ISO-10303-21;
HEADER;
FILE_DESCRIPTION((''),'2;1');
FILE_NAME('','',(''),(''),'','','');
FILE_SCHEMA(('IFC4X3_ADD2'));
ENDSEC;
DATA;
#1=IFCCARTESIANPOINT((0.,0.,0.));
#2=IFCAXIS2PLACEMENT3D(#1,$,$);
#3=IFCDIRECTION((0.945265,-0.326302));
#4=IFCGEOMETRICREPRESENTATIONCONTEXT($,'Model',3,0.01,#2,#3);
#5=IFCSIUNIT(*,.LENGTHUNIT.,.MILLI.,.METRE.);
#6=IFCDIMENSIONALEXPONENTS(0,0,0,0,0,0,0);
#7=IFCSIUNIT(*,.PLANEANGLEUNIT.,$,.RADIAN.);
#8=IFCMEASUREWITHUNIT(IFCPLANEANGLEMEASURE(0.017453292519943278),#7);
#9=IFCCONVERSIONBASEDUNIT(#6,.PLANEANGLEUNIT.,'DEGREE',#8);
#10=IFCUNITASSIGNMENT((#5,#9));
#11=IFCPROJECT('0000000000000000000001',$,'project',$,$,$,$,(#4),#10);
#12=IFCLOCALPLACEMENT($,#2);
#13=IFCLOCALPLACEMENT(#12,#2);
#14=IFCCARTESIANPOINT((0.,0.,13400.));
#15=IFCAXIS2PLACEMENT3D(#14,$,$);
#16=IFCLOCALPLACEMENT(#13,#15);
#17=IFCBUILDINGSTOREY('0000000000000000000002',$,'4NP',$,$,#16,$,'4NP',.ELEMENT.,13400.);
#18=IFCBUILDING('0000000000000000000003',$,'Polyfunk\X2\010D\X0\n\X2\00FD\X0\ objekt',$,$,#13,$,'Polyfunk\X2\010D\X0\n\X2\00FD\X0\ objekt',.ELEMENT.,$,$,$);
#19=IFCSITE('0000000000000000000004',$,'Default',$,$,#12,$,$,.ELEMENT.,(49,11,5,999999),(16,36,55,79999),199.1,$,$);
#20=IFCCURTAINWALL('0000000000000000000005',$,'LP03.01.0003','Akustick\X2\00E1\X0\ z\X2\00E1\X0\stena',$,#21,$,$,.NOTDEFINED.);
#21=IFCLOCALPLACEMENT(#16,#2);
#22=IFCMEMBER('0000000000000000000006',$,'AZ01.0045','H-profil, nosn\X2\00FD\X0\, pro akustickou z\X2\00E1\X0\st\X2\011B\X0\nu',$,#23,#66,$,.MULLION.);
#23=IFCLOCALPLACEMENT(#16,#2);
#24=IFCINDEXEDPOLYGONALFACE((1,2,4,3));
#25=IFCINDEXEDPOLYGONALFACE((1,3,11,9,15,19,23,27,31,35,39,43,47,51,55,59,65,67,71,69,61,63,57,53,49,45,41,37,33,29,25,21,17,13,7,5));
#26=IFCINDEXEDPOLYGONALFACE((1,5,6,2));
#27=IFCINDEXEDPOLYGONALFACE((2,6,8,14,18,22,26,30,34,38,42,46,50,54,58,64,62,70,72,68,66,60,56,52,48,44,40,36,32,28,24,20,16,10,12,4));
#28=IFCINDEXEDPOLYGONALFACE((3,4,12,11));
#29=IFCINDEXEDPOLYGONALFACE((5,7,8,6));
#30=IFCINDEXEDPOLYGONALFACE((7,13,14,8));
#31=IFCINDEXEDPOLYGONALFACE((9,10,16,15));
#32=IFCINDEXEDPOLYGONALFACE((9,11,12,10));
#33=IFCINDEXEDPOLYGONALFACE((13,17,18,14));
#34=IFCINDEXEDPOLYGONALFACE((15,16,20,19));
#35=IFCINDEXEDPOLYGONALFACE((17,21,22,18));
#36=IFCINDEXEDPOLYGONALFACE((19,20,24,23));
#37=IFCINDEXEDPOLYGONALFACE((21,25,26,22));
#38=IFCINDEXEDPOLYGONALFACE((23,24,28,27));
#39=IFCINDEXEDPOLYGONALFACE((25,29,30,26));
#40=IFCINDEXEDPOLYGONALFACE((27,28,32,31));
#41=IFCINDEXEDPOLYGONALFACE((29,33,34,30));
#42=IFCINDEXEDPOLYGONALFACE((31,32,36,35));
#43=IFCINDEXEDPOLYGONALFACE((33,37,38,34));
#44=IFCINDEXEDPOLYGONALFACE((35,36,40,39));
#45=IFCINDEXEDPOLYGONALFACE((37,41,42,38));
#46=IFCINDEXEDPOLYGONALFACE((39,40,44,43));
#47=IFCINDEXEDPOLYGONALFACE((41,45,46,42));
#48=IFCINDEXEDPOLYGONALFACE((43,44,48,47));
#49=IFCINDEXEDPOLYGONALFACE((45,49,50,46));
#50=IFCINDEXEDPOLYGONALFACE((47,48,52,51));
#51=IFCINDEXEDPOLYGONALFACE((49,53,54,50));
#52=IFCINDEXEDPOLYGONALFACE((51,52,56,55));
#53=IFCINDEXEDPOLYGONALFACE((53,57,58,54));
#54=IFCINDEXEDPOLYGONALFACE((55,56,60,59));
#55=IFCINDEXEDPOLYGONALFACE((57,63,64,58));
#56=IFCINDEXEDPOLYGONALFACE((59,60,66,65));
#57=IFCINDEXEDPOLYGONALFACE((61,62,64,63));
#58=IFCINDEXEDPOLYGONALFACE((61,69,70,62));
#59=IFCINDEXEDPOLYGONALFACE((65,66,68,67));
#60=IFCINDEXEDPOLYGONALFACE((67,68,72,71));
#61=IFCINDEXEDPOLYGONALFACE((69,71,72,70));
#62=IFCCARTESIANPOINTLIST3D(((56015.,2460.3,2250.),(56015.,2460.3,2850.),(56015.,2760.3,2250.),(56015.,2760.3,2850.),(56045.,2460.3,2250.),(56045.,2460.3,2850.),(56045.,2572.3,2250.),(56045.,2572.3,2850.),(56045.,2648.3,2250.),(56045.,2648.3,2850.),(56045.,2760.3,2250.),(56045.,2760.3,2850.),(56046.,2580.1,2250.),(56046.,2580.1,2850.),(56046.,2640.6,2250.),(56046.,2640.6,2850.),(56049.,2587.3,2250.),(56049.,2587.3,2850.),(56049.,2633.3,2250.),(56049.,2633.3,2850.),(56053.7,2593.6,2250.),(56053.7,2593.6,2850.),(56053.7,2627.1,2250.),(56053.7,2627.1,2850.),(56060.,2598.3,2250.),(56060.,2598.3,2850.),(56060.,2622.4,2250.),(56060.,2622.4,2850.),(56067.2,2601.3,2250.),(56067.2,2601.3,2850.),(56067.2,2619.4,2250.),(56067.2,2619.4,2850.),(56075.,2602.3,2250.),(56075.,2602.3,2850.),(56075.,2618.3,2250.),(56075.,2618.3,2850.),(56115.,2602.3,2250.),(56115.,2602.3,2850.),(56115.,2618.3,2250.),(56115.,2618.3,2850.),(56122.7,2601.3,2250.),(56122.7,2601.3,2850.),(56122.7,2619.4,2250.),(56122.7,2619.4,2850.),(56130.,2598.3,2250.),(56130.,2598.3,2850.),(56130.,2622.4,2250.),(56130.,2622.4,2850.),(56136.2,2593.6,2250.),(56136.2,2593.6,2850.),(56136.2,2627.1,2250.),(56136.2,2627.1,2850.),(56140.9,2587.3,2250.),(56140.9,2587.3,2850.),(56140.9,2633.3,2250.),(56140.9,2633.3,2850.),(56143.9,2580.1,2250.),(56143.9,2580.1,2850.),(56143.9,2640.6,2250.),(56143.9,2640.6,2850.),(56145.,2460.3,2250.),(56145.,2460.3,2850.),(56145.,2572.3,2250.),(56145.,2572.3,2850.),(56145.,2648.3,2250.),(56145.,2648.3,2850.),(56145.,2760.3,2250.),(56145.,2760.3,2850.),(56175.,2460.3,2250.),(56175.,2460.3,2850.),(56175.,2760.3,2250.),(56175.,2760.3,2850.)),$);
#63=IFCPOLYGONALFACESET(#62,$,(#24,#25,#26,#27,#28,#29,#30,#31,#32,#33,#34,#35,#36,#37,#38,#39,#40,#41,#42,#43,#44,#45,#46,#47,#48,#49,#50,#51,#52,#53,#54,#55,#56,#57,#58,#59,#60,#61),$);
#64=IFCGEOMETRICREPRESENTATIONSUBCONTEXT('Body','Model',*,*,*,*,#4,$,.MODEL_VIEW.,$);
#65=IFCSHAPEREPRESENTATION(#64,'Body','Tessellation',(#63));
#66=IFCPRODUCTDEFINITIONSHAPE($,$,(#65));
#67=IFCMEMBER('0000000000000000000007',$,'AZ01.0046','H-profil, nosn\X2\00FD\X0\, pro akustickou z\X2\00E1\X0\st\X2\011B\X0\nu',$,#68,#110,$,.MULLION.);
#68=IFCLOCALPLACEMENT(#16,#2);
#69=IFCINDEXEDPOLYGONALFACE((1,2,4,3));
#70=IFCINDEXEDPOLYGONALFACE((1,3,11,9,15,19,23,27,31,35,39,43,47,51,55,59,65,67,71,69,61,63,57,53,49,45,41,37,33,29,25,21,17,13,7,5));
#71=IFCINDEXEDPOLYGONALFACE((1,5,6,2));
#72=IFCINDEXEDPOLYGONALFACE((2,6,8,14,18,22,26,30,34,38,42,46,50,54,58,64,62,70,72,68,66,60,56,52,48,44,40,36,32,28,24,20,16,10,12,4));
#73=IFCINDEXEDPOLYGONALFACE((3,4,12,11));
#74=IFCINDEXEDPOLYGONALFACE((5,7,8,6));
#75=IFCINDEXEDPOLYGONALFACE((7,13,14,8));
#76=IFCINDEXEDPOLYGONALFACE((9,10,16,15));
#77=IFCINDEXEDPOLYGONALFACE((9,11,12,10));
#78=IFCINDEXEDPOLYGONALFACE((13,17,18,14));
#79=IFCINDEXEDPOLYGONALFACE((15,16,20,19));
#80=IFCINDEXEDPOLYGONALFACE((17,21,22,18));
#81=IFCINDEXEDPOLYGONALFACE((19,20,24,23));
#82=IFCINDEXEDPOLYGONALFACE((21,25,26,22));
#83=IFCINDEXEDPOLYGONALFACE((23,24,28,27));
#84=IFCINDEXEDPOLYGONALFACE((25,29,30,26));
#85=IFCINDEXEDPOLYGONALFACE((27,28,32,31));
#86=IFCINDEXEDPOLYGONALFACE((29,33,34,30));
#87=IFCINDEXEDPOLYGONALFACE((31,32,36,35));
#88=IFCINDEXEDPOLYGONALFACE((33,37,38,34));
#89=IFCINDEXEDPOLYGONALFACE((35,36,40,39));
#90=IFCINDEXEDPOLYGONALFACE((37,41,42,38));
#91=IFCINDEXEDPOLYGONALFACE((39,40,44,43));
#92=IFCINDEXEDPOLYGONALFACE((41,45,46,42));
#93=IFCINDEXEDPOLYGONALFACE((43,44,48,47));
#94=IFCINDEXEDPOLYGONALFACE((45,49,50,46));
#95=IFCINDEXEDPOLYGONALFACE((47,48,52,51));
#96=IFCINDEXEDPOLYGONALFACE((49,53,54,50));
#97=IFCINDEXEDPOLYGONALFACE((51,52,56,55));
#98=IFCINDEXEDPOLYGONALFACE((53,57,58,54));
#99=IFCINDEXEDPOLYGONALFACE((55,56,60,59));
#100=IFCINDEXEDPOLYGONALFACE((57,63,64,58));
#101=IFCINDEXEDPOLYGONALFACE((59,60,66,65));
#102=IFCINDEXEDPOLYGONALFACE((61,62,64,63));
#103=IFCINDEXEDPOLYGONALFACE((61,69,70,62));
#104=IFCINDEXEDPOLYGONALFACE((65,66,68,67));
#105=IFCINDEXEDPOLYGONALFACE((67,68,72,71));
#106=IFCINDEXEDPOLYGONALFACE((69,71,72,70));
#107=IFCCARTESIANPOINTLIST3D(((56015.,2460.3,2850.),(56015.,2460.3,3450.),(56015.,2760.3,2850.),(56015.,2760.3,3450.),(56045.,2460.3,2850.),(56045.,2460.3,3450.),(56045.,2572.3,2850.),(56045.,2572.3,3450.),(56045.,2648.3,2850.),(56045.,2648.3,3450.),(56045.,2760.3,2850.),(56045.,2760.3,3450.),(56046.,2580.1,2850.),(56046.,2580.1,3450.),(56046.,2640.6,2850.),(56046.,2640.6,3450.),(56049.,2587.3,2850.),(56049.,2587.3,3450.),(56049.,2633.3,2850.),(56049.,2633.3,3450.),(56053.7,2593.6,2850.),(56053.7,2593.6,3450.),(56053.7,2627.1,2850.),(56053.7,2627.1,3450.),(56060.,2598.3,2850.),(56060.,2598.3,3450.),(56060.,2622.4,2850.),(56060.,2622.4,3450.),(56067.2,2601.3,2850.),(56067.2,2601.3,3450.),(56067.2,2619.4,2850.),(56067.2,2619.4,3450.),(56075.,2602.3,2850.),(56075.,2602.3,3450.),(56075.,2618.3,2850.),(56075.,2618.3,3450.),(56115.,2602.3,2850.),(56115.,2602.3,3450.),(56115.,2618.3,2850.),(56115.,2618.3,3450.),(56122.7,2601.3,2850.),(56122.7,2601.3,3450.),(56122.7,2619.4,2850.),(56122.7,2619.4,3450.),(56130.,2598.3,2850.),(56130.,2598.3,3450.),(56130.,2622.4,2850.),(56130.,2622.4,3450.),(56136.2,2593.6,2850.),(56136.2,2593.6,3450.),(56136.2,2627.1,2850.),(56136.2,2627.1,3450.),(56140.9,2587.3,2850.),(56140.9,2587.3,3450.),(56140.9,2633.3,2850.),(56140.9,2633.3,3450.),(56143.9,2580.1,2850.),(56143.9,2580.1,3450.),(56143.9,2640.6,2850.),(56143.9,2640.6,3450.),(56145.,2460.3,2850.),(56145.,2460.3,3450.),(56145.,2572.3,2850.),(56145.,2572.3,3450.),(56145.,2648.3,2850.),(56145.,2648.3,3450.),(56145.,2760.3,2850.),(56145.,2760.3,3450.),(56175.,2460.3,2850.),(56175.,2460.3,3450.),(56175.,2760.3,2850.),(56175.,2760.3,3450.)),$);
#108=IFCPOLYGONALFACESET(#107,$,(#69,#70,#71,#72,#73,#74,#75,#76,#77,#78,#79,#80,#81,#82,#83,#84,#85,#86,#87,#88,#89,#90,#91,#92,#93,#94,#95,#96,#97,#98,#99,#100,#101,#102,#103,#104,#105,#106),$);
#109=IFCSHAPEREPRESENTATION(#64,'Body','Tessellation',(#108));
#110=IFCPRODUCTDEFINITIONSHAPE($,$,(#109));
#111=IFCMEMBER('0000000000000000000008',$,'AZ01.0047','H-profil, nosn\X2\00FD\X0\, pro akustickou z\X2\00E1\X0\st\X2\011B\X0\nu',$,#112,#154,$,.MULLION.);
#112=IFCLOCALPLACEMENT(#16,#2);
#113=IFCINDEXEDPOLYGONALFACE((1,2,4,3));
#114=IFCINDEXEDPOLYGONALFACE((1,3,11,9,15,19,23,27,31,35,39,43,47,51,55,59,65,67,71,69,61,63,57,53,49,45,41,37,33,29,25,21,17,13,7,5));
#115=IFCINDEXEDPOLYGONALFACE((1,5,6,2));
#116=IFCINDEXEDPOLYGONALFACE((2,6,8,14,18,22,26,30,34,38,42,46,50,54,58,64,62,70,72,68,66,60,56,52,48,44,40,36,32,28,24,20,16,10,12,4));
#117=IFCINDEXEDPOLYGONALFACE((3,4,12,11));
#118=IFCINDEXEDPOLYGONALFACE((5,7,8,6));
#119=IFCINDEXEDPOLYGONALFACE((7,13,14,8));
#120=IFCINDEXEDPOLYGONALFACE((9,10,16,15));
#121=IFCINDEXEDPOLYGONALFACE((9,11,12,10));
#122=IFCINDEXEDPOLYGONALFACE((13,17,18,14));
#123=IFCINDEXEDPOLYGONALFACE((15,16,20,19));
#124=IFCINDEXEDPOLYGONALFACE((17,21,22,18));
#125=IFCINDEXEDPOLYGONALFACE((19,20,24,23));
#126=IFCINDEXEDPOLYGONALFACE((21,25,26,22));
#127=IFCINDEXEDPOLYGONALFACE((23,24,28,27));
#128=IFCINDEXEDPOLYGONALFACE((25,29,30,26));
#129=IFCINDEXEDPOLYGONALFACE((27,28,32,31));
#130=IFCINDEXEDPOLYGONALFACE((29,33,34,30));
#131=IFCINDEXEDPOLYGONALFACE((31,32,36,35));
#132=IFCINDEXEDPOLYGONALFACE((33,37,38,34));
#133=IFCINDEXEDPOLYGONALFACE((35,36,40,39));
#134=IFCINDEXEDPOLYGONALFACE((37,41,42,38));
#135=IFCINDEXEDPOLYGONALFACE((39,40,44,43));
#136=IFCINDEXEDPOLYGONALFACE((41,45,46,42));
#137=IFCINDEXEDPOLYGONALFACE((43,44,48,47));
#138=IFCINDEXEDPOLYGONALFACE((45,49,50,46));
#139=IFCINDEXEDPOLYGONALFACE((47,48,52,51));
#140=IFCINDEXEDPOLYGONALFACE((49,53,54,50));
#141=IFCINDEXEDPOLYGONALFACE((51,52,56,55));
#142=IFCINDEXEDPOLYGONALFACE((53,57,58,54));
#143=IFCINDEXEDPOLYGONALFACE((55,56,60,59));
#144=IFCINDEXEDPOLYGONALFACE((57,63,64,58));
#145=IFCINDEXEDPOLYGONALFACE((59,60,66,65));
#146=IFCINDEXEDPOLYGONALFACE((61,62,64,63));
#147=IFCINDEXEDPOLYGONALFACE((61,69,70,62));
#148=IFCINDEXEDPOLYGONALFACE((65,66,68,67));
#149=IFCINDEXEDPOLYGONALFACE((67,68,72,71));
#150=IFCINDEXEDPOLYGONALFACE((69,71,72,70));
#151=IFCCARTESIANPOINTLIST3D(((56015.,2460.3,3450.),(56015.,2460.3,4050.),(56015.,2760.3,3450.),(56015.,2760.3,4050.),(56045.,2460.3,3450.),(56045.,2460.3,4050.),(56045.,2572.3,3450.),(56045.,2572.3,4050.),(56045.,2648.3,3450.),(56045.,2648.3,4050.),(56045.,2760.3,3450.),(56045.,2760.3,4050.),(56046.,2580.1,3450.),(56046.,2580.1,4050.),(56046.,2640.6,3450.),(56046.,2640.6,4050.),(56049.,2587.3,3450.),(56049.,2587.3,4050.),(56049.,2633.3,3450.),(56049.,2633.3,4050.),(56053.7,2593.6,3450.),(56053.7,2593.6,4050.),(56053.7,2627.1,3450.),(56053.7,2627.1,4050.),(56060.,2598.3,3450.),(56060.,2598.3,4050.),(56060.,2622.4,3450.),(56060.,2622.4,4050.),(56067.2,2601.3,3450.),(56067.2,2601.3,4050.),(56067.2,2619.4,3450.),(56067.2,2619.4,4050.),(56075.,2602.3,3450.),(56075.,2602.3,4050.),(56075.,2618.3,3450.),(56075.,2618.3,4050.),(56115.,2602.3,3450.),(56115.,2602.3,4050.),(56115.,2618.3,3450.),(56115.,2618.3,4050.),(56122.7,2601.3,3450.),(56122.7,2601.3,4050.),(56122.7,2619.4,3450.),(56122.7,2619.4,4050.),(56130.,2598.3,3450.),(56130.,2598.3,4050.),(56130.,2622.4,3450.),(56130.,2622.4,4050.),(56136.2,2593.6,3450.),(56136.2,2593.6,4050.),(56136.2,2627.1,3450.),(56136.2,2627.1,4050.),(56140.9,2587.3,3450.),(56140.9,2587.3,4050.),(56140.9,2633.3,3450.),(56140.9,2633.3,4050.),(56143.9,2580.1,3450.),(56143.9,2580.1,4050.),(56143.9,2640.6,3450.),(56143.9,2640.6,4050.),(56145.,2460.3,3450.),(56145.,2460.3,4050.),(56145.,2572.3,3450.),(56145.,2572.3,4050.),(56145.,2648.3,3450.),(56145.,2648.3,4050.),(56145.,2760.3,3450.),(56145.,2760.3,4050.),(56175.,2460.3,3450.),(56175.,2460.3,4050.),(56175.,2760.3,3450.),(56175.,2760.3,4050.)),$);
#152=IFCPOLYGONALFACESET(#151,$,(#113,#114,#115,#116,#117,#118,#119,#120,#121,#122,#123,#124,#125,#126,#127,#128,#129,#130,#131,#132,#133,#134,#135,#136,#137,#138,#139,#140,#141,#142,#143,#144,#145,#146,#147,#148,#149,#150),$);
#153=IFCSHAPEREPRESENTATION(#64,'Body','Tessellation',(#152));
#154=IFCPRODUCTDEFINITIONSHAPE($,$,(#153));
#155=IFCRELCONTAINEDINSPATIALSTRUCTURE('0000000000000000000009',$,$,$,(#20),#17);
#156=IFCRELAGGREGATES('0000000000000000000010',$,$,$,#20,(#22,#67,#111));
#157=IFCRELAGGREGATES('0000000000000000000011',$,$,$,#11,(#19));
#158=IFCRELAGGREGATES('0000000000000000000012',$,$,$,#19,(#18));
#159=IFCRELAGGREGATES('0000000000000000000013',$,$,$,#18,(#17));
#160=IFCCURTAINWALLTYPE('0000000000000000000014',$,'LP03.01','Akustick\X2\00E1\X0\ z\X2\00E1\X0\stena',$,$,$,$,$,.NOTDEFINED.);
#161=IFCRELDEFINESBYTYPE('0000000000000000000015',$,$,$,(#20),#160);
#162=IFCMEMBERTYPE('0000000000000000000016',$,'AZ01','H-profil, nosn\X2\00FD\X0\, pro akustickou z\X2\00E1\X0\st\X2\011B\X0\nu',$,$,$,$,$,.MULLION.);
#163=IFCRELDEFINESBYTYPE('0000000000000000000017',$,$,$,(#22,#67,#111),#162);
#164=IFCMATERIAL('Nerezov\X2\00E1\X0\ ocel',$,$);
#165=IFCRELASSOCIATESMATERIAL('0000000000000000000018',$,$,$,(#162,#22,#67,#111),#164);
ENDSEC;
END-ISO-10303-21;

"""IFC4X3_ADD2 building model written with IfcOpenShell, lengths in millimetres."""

from ifc_helpers import new_model, entity, si_unit, converted_unit, direction, frame, frame_2d, origin, place, context, subcontext, project, spatial, polyline, circle_curve, parameter, trimmed, segment, composite_curve, outline, extrude, source, transform, mapped, material, material_profile, profile_set, profile_usage, type_object, element, aggregate, save


model = new_model("IFC4X3_ADD2")

# Units and contexts
model_context = context("Model", 3, precision=0.01, world=origin(), true_north=direction((0.945265, -0.326302)))
body_context = subcontext(model_context, "Body", "Model", "MODEL_VIEW")
ifc_project = project(units=[si_unit("LENGTHUNIT", "METRE", prefix="MILLI"), converted_unit("PLANEANGLEUNIT", "DEGREE", entity("IfcPlaneAngleMeasure", 0.017453292519943278), si_unit("PLANEANGLEUNIT", "RADIAN"), dimensions=[0, 0, 0, 0, 0, 0, 0])], contexts=[model_context])

# Site, building, storey
site_placement = place(None, origin())
site = spatial("IfcSite", under=ifc_project, at=site_placement, Name="Default", CompositionType="ELEMENT", RefLatitude=(49, 11, 5, 999999), RefLongitude=(16, 36, 55, 79999), RefElevation=199.1)
building_placement = place(site_placement, origin())
building = spatial("IfcBuilding", under=site, at=building_placement, Name="Polyfunkčný objekt", LongName="Polyfunkčný objekt", CompositionType="ELEMENT")
storey_placement = place(building_placement, frame((0.0, 0.0, 13400.0)))
storey = spatial("IfcBuildingStorey", under=building, at=storey_placement, Name="4NP", LongName="4NP", CompositionType="ELEMENT", Elevation=13400.0)

# Shared definitions
curtain_wall_type = type_object("IfcCurtainWallType", Name="LP03.01", Description="Akustická zástena", PredefinedType="NOTDEFINED")
ifc_material_1 = material(Name="Nerezová ocel")
ifc_material_profile = material_profile(ifc_material_1, outline(composite_curve([segment(polyline([(50.0, -150.0), (80.0, -150.0)]), True, "CONTINUOUS"), segment(polyline([(80.0, -150.0), (80.0, 150.0)]), True, "CONTINUOUS"), segment(polyline([(80.0, 150.0), (50.0, 150.0)]), True, "CONTINUOUS"), segment(polyline([(50.0, 150.0), (50.0, 38.0)]), True, "CONTINUOUS"), segment(trimmed(circle_curve(frame_2d((20.0, 38.0), x_axis=(0.0, 1.0)), 30.0), [parameter(180.0)], [parameter(270.0)], True, "PARAMETER"), False, "CONTINUOUS"), segment(polyline([(20.0, 8.0), (-20.0, 8.0)]), True, "CONTINUOUS"), segment(trimmed(circle_curve(frame_2d((-20.0, 38.0), x_axis=(0.0, 1.0)), 30.0), [parameter(90.0)], [parameter(180.0)], True, "PARAMETER"), False, "CONTINUOUS"), segment(polyline([(-50.0, 38.0), (-50.0, 150.0)]), True, "CONTINUOUS"), segment(polyline([(-50.0, 150.0), (-80.0, 150.0)]), True, "CONTINUOUS"), segment(polyline([(-80.0, 150.0), (-80.0, -150.0)]), True, "CONTINUOUS"), segment(polyline([(-80.0, -150.0), (-50.0, -150.0)]), True, "CONTINUOUS"), segment(polyline([(-50.0, -150.0), (-50.0, -38.0)]), True, "CONTINUOUS"), segment(trimmed(circle_curve(frame_2d((-20.0, -38.0), x_axis=(0.0, 1.0)), 30.0), [parameter(0.0)], [parameter(90.0)], True, "PARAMETER"), False, "CONTINUOUS"), segment(polyline([(-20.0, -8.0), (20.0, -8.0)]), True, "CONTINUOUS"), segment(trimmed(circle_curve(frame_2d((20.0, -38.0), x_axis=(0.0, 1.0)), 30.0), [parameter(270.0)], [parameter(0.0)], True, "PARAMETER"), False, "CONTINUOUS"), segment(polyline([(50.0, -38.0), (50.0, -150.0)]), True, "CONTINUOUS")], self_intersect=False)), Name="Profil zástena")
ifc_profile_set = profile_set([ifc_material_profile], Name="Profil zástena")
ifc_profile_usage = profile_usage(ifc_profile_set)
member_type = type_object("IfcMemberType", Name="AZ01", Description="H-profil, nosný, pro akustickou zástěnu", PredefinedType="MULLION", material=ifc_profile_set)

# Curtain wall, members
curtain_wall_1_placement = place(storey_placement, frame((0.0, 0.0, -13400.0)))
curtain_wall_1 = element("IfcCurtainWall", 1, at=curtain_wall_1_placement, inside=storey, type_object=curtain_wall_type, Name="LP03.01.0003", Description="Akustická zástena", PredefinedType="NOTDEFINED")
shared_shape_1 = source(origin(), body_context, "Body", "SweptSolid", [
    extrude(outline(composite_curve([segment(polyline([(-150.0, -50.0), (-150.0, -80.0)]), True, "CONTINUOUS"), segment(polyline([(-150.0, -80.0), (150.0, -80.0)]), True, "CONTINUOUS"), segment(polyline([(150.0, -80.0), (150.0, -50.0)]), True, "CONTINUOUS"), segment(polyline([(150.0, -50.0), (38.0, -50.0)]), True, "CONTINUOUS"), segment(trimmed(circle_curve(frame_2d((38.0, -20.0), x_axis=(1.0, 0.0)), 30.0), [parameter(180.0)], [parameter(270.0)], True, "PARAMETER"), False, "CONTINUOUS"), segment(polyline([(8.0, -20.0), (8.0, 20.0)]), True, "CONTINUOUS"), segment(trimmed(circle_curve(frame_2d((38.0, 20.0), x_axis=(1.0, 0.0)), 30.0), [parameter(90.0)], [parameter(180.0)], True, "PARAMETER"), False, "CONTINUOUS"), segment(polyline([(38.0, 50.0), (150.0, 50.0)]), True, "CONTINUOUS"), segment(polyline([(150.0, 50.0), (150.0, 80.0)]), True, "CONTINUOUS"), segment(polyline([(150.0, 80.0), (-150.0, 80.0)]), True, "CONTINUOUS"), segment(polyline([(-150.0, 80.0), (-150.0, 50.0)]), True, "CONTINUOUS"), segment(polyline([(-150.0, 50.0), (-38.0, 50.0)]), True, "CONTINUOUS"), segment(trimmed(circle_curve(frame_2d((-38.0, 20.0), x_axis=(1.0, 0.0)), 30.0), [parameter(0.0)], [parameter(90.0)], True, "PARAMETER"), False, "CONTINUOUS"), segment(polyline([(-8.0, 20.0), (-8.0, -20.0)]), True, "CONTINUOUS"), segment(trimmed(circle_curve(frame_2d((-38.0, -20.0), x_axis=(1.0, 0.0)), 30.0), [parameter(270.0)], [parameter(0.0)], True, "PARAMETER"), False, "CONTINUOUS"), segment(polyline([(-38.0, -50.0), (-150.0, -50.0)]), True, "CONTINUOUS")], self_intersect=False)), frame((0.0, 0.0, -600.0), z_axis=(0.0, 0.0, -1.0), x_axis=(1.0, 0.0, 0.0)), (0.0, 0.0, -1.0), 600.0),
])
member_1_placement = place(curtain_wall_1_placement, frame((56095.0, 2610.3, 15650.0), z_axis=(0.0, 0.0, -1.0), x_axis=(0.0, 1.0, 0.0)))
member_1 = element("IfcMember", 2, at=member_1_placement, type_object=member_type, material=ifc_profile_usage, Name="AZ01.0045", Description="H-profil, nosný, pro akustickou zástěnu", PredefinedType="MULLION", context=body_context, shape_type="MappedRepresentation", body=[
    mapped(shared_shape_1, transform((0.0, 0.0, 0.0), scale=1.0)),
])
member_2_placement = place(curtain_wall_1_placement, frame((56095.0, 2610.3, 16250.0), z_axis=(0.0, 0.0, -1.0), x_axis=(0.0, 1.0, 0.0)))
member_2 = element("IfcMember", 3, at=member_2_placement, type_object=member_type, material=ifc_profile_usage, Name="AZ01.0046", Description="H-profil, nosný, pro akustickou zástěnu", PredefinedType="MULLION", context=body_context, shape_type="MappedRepresentation", body=[
    mapped(shared_shape_1, transform((0.0, 0.0, 0.0), scale=1.0)),
])
member_3_placement = place(curtain_wall_1_placement, frame((56095.0, 2610.3, 16850.0), z_axis=(0.0, 0.0, -1.0), x_axis=(0.0, 1.0, 0.0)))
member_3 = element("IfcMember", 4, at=member_3_placement, type_object=member_type, material=ifc_profile_usage, Name="AZ01.0047", Description="H-profil, nosný, pro akustickou zástěnu", PredefinedType="MULLION", context=body_context, shape_type="MappedRepresentation", body=[
    mapped(shared_shape_1, transform((0.0, 0.0, 0.0), scale=1.0)),
])
aggregate(curtain_wall_1, [member_1, member_2, member_3])

save(model, "model.ifc")
